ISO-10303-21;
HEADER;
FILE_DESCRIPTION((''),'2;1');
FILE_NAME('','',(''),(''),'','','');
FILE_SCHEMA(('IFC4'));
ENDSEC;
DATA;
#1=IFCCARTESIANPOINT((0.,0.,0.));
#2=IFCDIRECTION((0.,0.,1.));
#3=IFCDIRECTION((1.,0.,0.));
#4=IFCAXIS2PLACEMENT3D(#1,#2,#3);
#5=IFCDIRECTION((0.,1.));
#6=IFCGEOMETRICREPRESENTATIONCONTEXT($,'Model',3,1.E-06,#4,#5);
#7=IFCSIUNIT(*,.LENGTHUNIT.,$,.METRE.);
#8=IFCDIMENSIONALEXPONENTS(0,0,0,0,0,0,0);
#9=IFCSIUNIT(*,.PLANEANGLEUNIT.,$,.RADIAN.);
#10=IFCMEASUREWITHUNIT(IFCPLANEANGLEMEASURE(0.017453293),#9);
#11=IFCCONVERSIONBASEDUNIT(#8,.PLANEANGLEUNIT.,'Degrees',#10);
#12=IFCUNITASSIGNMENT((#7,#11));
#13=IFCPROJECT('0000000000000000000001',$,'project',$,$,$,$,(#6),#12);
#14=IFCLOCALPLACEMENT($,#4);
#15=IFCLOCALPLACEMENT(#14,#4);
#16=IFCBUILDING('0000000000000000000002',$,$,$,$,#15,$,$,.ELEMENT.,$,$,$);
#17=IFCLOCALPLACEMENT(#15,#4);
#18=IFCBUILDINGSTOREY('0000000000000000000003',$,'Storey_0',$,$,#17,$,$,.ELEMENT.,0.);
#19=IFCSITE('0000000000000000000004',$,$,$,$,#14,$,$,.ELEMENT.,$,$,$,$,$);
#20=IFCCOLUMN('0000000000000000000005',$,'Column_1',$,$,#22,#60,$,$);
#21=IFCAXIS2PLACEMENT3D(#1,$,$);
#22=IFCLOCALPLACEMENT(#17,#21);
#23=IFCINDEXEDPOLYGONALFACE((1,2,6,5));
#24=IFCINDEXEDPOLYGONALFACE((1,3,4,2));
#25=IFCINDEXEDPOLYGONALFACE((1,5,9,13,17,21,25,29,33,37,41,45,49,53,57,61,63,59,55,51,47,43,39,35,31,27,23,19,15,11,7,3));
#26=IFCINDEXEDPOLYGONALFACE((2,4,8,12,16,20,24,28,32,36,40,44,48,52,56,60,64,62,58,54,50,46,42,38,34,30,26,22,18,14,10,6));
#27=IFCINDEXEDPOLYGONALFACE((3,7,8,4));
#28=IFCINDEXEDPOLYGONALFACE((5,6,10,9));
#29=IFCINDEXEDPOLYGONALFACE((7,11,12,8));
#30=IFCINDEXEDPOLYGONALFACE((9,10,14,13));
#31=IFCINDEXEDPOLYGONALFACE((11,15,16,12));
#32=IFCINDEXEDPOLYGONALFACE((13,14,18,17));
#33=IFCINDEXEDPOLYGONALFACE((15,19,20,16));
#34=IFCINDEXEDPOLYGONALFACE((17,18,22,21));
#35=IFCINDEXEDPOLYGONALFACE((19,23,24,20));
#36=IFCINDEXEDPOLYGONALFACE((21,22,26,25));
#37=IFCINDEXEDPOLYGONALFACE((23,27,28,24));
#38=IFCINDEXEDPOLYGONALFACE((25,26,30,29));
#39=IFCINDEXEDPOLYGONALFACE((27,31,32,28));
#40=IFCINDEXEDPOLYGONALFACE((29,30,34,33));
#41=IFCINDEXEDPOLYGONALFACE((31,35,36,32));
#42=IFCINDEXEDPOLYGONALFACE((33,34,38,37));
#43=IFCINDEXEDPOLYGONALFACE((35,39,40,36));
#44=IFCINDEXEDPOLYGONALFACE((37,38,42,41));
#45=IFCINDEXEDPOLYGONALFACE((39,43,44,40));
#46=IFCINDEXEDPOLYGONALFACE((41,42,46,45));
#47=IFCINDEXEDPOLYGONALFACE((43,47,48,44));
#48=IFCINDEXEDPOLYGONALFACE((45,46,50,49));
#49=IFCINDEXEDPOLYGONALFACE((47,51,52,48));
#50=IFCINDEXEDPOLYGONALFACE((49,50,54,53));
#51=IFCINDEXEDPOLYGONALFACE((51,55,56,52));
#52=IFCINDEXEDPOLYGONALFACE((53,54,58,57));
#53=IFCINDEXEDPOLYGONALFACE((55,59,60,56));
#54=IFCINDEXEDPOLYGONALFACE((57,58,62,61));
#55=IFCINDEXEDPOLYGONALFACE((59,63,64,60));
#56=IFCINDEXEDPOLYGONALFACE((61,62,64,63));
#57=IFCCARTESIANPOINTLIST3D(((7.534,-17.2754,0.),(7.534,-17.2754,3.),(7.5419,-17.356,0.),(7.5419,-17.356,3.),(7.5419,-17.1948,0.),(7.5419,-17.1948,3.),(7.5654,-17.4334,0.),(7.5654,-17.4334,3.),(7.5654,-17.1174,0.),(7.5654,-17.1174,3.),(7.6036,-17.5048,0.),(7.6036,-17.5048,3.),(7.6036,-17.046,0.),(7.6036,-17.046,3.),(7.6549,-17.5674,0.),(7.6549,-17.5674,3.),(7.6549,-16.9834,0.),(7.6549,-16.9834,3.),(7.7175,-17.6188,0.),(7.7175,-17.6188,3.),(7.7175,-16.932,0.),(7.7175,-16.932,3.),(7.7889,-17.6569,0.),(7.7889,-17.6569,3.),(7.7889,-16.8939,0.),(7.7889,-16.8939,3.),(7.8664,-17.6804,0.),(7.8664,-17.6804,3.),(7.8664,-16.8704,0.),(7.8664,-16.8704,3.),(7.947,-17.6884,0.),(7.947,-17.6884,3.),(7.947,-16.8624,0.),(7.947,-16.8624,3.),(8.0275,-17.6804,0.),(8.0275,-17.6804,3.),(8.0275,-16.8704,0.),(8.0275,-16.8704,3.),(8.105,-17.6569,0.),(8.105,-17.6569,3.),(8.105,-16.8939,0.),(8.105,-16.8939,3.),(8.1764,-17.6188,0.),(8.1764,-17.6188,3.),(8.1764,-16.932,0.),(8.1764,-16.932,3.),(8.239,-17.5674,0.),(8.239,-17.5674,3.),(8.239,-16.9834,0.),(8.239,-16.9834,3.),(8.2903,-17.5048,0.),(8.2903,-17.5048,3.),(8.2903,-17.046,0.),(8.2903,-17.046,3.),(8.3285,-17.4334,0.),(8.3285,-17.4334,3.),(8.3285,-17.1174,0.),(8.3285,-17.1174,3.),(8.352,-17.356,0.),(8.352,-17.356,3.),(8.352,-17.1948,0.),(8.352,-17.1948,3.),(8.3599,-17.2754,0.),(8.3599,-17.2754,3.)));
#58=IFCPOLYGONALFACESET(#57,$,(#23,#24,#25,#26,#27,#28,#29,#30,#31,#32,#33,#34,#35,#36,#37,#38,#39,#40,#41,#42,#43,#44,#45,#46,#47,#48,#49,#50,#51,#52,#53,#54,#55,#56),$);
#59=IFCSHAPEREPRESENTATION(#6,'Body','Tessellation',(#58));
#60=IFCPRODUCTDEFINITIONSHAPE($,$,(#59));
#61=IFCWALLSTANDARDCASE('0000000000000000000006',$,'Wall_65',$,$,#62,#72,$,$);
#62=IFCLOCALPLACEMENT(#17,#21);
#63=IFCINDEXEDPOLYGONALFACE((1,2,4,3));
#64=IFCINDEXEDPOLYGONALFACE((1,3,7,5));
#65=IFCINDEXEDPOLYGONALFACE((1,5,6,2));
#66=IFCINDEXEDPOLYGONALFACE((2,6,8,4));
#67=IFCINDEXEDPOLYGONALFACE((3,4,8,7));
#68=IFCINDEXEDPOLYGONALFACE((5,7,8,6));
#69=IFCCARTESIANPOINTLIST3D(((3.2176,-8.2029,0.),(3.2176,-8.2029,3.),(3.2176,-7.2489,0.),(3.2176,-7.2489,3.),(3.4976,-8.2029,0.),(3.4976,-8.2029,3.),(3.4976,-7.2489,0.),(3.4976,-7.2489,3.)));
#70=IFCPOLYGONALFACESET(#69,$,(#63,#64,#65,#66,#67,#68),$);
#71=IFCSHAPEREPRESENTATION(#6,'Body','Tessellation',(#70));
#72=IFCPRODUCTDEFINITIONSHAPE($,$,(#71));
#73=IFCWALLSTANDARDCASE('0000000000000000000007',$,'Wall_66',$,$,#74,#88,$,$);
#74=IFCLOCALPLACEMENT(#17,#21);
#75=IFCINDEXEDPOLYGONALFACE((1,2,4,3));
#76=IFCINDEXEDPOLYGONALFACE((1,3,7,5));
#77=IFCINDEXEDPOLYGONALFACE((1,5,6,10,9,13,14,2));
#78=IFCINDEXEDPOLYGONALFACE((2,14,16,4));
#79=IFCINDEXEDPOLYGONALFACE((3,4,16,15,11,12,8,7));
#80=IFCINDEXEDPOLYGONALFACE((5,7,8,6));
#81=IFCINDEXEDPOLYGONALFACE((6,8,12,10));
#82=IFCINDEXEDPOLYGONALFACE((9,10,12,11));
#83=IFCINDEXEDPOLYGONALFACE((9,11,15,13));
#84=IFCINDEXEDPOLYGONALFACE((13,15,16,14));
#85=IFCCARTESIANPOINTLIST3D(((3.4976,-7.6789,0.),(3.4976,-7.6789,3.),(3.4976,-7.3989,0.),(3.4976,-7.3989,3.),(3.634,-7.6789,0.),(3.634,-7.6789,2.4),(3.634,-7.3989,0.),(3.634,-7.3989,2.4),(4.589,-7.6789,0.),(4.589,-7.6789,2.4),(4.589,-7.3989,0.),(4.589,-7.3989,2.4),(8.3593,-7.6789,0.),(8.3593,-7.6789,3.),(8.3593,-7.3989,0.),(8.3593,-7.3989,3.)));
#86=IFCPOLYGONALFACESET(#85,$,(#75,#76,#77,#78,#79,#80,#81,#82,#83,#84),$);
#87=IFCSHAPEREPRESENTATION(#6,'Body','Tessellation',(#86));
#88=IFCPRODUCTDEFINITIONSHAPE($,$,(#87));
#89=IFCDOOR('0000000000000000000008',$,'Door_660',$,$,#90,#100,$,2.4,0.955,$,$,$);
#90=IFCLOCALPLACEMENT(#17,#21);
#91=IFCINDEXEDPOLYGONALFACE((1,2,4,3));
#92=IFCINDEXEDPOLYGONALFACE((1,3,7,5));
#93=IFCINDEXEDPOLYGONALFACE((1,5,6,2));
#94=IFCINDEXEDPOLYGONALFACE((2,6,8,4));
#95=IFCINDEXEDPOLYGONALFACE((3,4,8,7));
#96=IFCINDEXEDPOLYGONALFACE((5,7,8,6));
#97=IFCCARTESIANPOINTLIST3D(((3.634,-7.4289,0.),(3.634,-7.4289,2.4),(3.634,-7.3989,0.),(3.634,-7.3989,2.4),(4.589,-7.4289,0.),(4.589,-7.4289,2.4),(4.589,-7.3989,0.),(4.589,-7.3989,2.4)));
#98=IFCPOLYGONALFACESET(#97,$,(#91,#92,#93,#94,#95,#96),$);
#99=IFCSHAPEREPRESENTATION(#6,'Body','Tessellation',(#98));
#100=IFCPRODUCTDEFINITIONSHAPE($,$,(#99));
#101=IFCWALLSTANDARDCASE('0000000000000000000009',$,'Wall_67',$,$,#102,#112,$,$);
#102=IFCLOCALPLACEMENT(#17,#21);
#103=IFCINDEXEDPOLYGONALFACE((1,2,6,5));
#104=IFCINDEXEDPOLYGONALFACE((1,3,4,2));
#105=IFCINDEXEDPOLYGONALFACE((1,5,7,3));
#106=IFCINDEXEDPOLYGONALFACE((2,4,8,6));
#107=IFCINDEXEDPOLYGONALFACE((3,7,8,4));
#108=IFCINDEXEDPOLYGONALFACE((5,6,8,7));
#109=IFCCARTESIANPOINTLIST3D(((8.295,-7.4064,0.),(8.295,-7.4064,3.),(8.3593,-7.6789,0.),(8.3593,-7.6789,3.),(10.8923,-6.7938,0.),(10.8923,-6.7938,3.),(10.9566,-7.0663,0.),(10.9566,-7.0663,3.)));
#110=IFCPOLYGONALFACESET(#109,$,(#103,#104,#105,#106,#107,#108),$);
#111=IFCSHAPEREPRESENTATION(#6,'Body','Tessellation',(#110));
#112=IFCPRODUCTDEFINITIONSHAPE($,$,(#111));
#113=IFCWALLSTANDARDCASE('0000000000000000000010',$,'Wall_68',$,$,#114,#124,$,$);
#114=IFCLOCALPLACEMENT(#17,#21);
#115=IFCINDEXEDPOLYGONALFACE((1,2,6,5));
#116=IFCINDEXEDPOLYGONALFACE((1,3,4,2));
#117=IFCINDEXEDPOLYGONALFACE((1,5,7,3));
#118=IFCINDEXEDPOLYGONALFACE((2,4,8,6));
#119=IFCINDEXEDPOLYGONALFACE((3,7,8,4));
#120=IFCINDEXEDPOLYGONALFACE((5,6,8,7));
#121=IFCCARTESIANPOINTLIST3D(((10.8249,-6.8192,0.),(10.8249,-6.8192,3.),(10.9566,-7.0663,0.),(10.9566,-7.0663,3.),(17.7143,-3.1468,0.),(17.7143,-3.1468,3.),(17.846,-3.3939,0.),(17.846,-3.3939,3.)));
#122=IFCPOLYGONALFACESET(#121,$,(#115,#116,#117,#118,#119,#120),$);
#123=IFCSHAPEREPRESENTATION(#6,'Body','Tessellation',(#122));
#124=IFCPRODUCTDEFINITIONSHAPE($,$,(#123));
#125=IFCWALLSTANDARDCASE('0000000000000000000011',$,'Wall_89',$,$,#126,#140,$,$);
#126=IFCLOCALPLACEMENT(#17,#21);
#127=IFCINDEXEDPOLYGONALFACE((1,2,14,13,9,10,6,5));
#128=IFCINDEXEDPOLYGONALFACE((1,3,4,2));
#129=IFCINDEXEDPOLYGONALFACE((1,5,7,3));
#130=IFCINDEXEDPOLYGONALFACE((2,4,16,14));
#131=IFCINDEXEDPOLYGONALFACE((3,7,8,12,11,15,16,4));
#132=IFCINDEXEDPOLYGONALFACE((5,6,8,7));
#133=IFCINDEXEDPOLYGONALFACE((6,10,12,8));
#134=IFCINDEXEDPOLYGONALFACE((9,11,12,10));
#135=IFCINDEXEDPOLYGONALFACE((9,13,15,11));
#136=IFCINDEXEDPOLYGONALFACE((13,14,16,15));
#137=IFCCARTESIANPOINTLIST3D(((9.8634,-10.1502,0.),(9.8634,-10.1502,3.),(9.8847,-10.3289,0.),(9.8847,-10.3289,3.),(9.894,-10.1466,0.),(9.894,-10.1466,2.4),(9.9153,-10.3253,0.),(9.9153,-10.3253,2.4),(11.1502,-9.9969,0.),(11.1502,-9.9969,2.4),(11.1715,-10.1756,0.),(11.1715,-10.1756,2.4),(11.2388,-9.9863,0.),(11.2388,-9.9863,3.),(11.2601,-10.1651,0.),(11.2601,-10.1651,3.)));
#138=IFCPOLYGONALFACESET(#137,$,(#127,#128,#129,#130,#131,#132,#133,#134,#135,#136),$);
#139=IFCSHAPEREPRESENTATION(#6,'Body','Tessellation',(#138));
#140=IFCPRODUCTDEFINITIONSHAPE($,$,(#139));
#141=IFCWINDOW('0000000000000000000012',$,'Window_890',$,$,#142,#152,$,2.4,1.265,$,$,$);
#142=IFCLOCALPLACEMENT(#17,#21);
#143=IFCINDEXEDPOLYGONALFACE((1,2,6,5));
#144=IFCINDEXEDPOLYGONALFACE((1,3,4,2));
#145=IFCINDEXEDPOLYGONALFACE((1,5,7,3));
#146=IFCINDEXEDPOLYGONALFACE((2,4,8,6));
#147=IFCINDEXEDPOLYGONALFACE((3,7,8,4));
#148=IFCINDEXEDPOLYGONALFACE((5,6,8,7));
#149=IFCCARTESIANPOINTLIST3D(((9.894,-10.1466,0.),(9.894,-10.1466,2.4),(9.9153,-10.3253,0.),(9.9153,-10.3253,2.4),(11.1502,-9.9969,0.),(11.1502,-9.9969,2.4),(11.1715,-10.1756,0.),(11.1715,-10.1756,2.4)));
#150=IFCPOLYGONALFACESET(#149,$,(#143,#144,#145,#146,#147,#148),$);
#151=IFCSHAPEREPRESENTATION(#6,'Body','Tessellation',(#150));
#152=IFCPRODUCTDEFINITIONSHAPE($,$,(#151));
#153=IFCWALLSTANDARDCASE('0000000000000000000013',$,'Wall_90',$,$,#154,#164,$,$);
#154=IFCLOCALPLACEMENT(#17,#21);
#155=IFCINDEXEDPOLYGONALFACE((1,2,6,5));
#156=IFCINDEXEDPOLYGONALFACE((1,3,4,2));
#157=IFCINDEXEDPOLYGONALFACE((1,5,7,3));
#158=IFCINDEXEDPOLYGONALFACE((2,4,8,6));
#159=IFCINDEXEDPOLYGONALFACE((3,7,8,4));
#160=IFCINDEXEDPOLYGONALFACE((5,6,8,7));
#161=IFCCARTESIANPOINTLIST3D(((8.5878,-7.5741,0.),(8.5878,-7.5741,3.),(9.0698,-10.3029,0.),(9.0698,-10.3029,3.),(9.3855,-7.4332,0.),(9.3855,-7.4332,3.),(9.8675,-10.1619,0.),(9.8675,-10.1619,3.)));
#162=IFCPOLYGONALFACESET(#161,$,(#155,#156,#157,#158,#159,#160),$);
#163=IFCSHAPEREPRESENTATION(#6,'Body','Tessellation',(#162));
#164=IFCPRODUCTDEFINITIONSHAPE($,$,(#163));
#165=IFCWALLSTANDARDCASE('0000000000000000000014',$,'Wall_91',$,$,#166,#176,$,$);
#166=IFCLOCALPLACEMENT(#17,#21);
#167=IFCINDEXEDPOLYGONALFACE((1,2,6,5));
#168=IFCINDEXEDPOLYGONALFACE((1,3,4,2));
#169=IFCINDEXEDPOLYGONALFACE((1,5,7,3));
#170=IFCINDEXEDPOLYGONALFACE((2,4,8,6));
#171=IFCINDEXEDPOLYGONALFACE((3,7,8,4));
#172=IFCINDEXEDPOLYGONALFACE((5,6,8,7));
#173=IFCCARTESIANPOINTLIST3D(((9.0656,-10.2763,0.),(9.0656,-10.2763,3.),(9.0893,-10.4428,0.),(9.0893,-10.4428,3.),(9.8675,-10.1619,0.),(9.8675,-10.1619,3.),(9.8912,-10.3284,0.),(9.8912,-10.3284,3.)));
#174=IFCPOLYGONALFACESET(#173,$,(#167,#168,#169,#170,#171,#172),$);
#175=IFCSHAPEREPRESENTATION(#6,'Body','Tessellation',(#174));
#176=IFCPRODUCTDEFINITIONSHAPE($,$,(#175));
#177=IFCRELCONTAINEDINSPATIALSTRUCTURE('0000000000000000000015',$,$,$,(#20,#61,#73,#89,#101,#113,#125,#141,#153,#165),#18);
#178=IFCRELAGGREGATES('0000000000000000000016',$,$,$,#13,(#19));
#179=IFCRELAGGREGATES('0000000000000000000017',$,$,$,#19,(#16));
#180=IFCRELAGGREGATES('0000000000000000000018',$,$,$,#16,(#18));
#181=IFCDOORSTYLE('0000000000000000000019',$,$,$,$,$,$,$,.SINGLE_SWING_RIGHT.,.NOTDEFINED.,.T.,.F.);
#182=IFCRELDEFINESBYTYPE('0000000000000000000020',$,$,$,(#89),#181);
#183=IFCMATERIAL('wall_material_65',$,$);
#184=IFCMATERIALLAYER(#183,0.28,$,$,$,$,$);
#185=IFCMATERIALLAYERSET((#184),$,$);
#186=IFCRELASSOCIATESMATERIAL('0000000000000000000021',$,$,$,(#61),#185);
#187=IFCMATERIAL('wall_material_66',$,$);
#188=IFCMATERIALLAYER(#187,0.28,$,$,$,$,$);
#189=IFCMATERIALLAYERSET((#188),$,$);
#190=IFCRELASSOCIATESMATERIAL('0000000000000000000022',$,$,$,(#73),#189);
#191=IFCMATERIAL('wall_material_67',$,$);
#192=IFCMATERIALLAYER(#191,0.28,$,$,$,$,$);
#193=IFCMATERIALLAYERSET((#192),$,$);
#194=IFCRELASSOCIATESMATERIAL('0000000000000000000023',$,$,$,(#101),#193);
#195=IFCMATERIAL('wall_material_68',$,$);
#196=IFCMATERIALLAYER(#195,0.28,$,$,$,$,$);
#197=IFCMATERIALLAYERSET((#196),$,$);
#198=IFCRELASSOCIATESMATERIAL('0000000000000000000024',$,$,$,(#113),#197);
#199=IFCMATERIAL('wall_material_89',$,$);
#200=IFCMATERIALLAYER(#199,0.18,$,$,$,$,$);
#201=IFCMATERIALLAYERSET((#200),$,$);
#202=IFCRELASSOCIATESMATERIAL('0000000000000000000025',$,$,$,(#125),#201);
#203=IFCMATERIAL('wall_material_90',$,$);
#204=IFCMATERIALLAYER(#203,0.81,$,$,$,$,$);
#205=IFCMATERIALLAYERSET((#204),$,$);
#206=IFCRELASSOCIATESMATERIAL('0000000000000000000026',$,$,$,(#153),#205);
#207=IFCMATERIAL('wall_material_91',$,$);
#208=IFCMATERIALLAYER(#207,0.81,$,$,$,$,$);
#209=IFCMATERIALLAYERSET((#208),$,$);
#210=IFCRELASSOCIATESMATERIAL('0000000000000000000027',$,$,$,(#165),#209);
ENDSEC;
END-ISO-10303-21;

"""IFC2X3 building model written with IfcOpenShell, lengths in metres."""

from ifc_helpers import new_model, entity, si_unit, converted_unit, direction, frame, frame_2d, origin_with_axes, origin_2d_with_axis, place, context, project, spatial, polyline, rectangle, circle, outline, extrude, material, layer, layer_set, layer_usage, type_object, element, fill, save


model = new_model("IFC2X3")

# Units and contexts
model_context = context("Model", 3, precision=1e-06, world=origin_with_axes(), true_north=direction((0.0, 1.0)))
ifc_project = project(units=[si_unit("LENGTHUNIT", "METRE"), converted_unit("PLANEANGLEUNIT", "Degrees", entity("IfcPlaneAngleMeasure", 0.017453293), si_unit("PLANEANGLEUNIT", "RADIAN"), dimensions=[0, 0, 0, 0, 0, 0, 0])], contexts=[model_context])

# Site, building, storey
site_placement = place(None, origin_with_axes())
site = spatial("IfcSite", under=ifc_project, at=site_placement, CompositionType="ELEMENT")
building_placement = place(site_placement, origin_with_axes())
building = spatial("IfcBuilding", under=site, at=building_placement, CompositionType="ELEMENT")
storey_placement = place(building_placement, origin_with_axes())
storey = spatial("IfcBuildingStorey", under=building, at=storey_placement, Name="Storey_0", CompositionType="ELEMENT", Elevation=0.0)

# Column
column_placement = place(storey_placement, frame((7.947, -17.2754, 0.0), z_axis=(0.0, 0.0, 1.0), x_axis=(1.0, 0.0, 0.0)))
element("IfcColumn", 1, at=column_placement, inside=storey, Name="Column_1", context=model_context, shape_type="SweptSolid", body=[
    extrude(circle(Radius=0.413, at=origin_2d_with_axis()), origin_with_axes(), (0.0, 0.0, 1.0), 3.0),
])

# Wall
ifc_material_1 = material(Name="wall_material_65")
ifc_layer_1 = layer(ifc_material_1, 0.28)
ifc_layer_set_1 = layer_set([ifc_layer_1])
ifc_layer_usage_1 = layer_usage(ifc_layer_set_1, "AXIS2", "POSITIVE", 0.0)
wall_1_placement = place(storey_placement, frame((3.4976, -8.2029, 0.0), z_axis=(0.0, 0.0, 1.0), x_axis=(0.0, 1.0, 0.0)))
element("IfcWallStandardCase", 2, at=wall_1_placement, inside=storey, material=ifc_layer_usage_1, Name="Wall_65", context=model_context, shape_type="SweptSolid", body=[
    extrude(outline(polyline([(0.0, 0.28), (0.954, 0.28), (0.954, 0.0), (0.0, 0.0), (0.0, 0.28)])), origin_with_axes(), (0.0, 0.0, 1.0), 3.0),
])

# Wall, opening, door
ifc_material_2 = material(Name="wall_material_66")
ifc_layer_2 = layer(ifc_material_2, 0.28)
ifc_layer_set_2 = layer_set([ifc_layer_2])
ifc_layer_usage_2 = layer_usage(ifc_layer_set_2, "AXIS2", "NEGATIVE", 0.0)
wall_2_placement = place(storey_placement, frame((3.4976, -7.3989, 0.0), z_axis=(0.0, 0.0, 1.0), x_axis=(1.0, 0.0, 0.0)))
wall_2 = element("IfcWallStandardCase", 3, at=wall_2_placement, inside=storey, material=ifc_layer_usage_2, Name="Wall_66", context=model_context, shape_type="SweptSolid", body=[
    extrude(outline(polyline([(0.0, 0.0), (4.8617, 0.0), (4.8617, -0.28), (0.0, -0.28), (0.0, 0.0)])), origin_with_axes(), (0.0, 0.0, 1.0), 3.0),
])
opening_1_placement = place(wall_2_placement, frame((0.1364, 0.0, 0.0), z_axis=(0.0, 0.0, 1.0), x_axis=(1.0, 0.0, 0.0)))
opening_1 = element("IfcOpeningElement", 4, at=opening_1_placement, cuts=wall_2, context=model_context, shape_type="SweptSolid", body=[
    extrude(rectangle(XDim=0.955, YDim=2.4, at=frame_2d((1.2, -0.4775), x_axis=(0.0, 1.0))), frame((0.0, 0.01, 0.0), z_axis=(0.0, -1.0, 0.0), x_axis=(0.0, 0.0, 1.0)), (0.0, 0.0, 1.0), 0.3),
])
door_style = type_object("IfcDoorStyle", ConstructionType="NOTDEFINED", OperationType="SINGLE_SWING_RIGHT", ParameterTakesPrecedence=True, Sizeable=False)
door_placement = place(storey_placement, origin_with_axes())
door = element("IfcDoor", 5, at=door_placement, inside=storey, type_object=door_style, Name="Door_660", OverallHeight=2.4, OverallWidth=0.955, context=model_context, shape_type="SweptSolid", body=[
    extrude(outline(polyline([(3.634, -7.3989), (4.589, -7.3989), (4.589, -7.4289), (3.634, -7.4289), (3.634, -7.3989)])), origin_with_axes(), (0.0, 0.0, 1.0), 2.4),
])
fill(opening_1, door)

# Walls
ifc_material_3 = material(Name="wall_material_67")
ifc_layer_3 = layer(ifc_material_3, 0.28)
ifc_layer_set_3 = layer_set([ifc_layer_3])
ifc_layer_usage_3 = layer_usage(ifc_layer_set_3, "AXIS2", "NEGATIVE", 0.0)
wall_3_placement = place(storey_placement, frame((8.295, -7.4064, 0.0), z_axis=(0.0, 0.0, 1.0), x_axis=(0.973295, 0.22956, 0.0)))
element("IfcWallStandardCase", 6, at=wall_3_placement, inside=storey, material=ifc_layer_usage_3, Name="Wall_67", context=model_context, shape_type="SweptSolid", body=[
    extrude(outline(polyline([(0.0, 0.0), (2.6685, 0.0), (2.6685, -0.28), (0.0, -0.28), (0.0, 0.0)])), origin_with_axes(), (0.0, 0.0, 1.0), 3.0),
])
ifc_material_4 = material(Name="wall_material_68")
ifc_layer_4 = layer(ifc_material_4, 0.28)
ifc_layer_set_4 = layer_set([ifc_layer_4])
ifc_layer_usage_4 = layer_usage(ifc_layer_set_4, "AXIS2", "NEGATIVE", 0.0)
wall_4_placement = place(storey_placement, frame((10.8249, -6.8192, 0.0), z_axis=(0.0, 0.0, 1.0), x_axis=(0.882455, 0.470396, 0.0)))
element("IfcWallStandardCase", 7, at=wall_4_placement, inside=storey, material=ifc_layer_usage_4, Name="Wall_68", context=model_context, shape_type="SweptSolid", body=[
    extrude(outline(polyline([(0.0, 0.0), (7.8071, 0.0), (7.8071, -0.28), (0.0, -0.28), (0.0, 0.0)])), origin_with_axes(), (0.0, 0.0, 1.0), 3.0),
])

# Wall, opening, window
ifc_material_5 = material(Name="wall_material_89")
ifc_layer_5 = layer(ifc_material_5, 0.18)
ifc_layer_set_5 = layer_set([ifc_layer_5])
ifc_layer_usage_5 = layer_usage(ifc_layer_set_5, "AXIS2", "POSITIVE", 0.0)
wall_5_placement = place(storey_placement, frame((11.2388, -9.9863, 0.0), z_axis=(0.0, 0.0, 1.0), x_axis=(-0.992975, -0.118322, 0.0)))
wall_5 = element("IfcWallStandardCase", 8, at=wall_5_placement, inside=storey, material=ifc_layer_usage_5, Name="Wall_89", context=model_context, shape_type="SweptSolid", body=[
    extrude(outline(polyline([(0.0, 0.18), (1.3851, 0.18), (1.3851, 0.0), (0.0, 0.0), (0.0, 0.18)])), origin_with_axes(), (0.0, 0.0, 1.0), 3.0),
])
opening_2_placement = place(wall_5_placement, frame((0.0892, 0.18, 0.0), z_axis=(0.0, 0.0, 1.0), x_axis=(1.0, 0.0, 0.0)))
opening_2 = element("IfcOpeningElement", 9, at=opening_2_placement, cuts=wall_5, context=model_context, shape_type="SweptSolid", body=[
    extrude(rectangle(XDim=1.265, YDim=2.4, at=frame_2d((1.2, -0.6325), x_axis=(0.0, 1.0))), frame((0.0, 0.01, 0.0), z_axis=(0.0, -1.0, 0.0), x_axis=(0.0, 0.0, 1.0)), (0.0, 0.0, 1.0), 0.2),
])
window_1_placement = place(storey_placement, origin_with_axes())
window_1 = element("IfcWindow", 10, at=window_1_placement, inside=storey, Name="Window_890", OverallHeight=2.4, OverallWidth=1.265, context=model_context, shape_type="SweptSolid", body=[
    extrude(outline(polyline([(11.1715, -10.1756), (9.9153, -10.3253), (9.894, -10.1466), (11.1502, -9.9969), (11.1715, -10.1756)])), origin_with_axes(), (0.0, 0.0, 1.0), 2.4),
])
fill(opening_2, window_1)

# Walls
ifc_material_6 = material(Name="wall_material_90")
ifc_layer_6 = layer(ifc_material_6, 0.81)
ifc_layer_set_6 = layer_set([ifc_layer_6])
ifc_layer_usage_6 = layer_usage(ifc_layer_set_6, "AXIS2", "NEGATIVE", 0.0)
wall_6_placement = place(storey_placement, frame((9.3855, -7.4332, 0.0), z_axis=(0.0, 0.0, 1.0), x_axis=(0.173951, -0.984754, 0.0)))
element("IfcWallStandardCase", 11, at=wall_6_placement, inside=storey, material=ifc_layer_usage_6, Name="Wall_90", context=model_context, shape_type="SweptSolid", body=[
    extrude(outline(polyline([(0.0, 0.0), (2.771, 0.0), (2.771, -0.81), (0.0, -0.81), (0.0, 0.0)])), origin_with_axes(), (0.0, 0.0, 1.0), 3.0),
])
ifc_material_7 = material(Name="wall_material_91")
ifc_layer_7 = layer(ifc_material_7, 0.81)
ifc_layer_set_7 = layer_set([ifc_layer_7])
ifc_layer_usage_7 = layer_usage(ifc_layer_set_7, "AXIS2", "NEGATIVE", 0.0)
wall_7_placement = place(storey_placement, frame((9.8675, -10.1619, 0.0), z_axis=(0.0, 0.0, 1.0), x_axis=(0.14119, -0.989982, 0.0)))
element("IfcWallStandardCase", 12, at=wall_7_placement, inside=storey, material=ifc_layer_usage_7, Name="Wall_91", context=model_context, shape_type="SweptSolid", body=[
    extrude(outline(polyline([(0.0, 0.0), (0.1682, 0.0), (0.1682, -0.81), (0.0, -0.81), (0.0, 0.0)])), origin_with_axes(), (0.0, 0.0, 1.0), 3.0),
])

save(model, "model.ifc")
